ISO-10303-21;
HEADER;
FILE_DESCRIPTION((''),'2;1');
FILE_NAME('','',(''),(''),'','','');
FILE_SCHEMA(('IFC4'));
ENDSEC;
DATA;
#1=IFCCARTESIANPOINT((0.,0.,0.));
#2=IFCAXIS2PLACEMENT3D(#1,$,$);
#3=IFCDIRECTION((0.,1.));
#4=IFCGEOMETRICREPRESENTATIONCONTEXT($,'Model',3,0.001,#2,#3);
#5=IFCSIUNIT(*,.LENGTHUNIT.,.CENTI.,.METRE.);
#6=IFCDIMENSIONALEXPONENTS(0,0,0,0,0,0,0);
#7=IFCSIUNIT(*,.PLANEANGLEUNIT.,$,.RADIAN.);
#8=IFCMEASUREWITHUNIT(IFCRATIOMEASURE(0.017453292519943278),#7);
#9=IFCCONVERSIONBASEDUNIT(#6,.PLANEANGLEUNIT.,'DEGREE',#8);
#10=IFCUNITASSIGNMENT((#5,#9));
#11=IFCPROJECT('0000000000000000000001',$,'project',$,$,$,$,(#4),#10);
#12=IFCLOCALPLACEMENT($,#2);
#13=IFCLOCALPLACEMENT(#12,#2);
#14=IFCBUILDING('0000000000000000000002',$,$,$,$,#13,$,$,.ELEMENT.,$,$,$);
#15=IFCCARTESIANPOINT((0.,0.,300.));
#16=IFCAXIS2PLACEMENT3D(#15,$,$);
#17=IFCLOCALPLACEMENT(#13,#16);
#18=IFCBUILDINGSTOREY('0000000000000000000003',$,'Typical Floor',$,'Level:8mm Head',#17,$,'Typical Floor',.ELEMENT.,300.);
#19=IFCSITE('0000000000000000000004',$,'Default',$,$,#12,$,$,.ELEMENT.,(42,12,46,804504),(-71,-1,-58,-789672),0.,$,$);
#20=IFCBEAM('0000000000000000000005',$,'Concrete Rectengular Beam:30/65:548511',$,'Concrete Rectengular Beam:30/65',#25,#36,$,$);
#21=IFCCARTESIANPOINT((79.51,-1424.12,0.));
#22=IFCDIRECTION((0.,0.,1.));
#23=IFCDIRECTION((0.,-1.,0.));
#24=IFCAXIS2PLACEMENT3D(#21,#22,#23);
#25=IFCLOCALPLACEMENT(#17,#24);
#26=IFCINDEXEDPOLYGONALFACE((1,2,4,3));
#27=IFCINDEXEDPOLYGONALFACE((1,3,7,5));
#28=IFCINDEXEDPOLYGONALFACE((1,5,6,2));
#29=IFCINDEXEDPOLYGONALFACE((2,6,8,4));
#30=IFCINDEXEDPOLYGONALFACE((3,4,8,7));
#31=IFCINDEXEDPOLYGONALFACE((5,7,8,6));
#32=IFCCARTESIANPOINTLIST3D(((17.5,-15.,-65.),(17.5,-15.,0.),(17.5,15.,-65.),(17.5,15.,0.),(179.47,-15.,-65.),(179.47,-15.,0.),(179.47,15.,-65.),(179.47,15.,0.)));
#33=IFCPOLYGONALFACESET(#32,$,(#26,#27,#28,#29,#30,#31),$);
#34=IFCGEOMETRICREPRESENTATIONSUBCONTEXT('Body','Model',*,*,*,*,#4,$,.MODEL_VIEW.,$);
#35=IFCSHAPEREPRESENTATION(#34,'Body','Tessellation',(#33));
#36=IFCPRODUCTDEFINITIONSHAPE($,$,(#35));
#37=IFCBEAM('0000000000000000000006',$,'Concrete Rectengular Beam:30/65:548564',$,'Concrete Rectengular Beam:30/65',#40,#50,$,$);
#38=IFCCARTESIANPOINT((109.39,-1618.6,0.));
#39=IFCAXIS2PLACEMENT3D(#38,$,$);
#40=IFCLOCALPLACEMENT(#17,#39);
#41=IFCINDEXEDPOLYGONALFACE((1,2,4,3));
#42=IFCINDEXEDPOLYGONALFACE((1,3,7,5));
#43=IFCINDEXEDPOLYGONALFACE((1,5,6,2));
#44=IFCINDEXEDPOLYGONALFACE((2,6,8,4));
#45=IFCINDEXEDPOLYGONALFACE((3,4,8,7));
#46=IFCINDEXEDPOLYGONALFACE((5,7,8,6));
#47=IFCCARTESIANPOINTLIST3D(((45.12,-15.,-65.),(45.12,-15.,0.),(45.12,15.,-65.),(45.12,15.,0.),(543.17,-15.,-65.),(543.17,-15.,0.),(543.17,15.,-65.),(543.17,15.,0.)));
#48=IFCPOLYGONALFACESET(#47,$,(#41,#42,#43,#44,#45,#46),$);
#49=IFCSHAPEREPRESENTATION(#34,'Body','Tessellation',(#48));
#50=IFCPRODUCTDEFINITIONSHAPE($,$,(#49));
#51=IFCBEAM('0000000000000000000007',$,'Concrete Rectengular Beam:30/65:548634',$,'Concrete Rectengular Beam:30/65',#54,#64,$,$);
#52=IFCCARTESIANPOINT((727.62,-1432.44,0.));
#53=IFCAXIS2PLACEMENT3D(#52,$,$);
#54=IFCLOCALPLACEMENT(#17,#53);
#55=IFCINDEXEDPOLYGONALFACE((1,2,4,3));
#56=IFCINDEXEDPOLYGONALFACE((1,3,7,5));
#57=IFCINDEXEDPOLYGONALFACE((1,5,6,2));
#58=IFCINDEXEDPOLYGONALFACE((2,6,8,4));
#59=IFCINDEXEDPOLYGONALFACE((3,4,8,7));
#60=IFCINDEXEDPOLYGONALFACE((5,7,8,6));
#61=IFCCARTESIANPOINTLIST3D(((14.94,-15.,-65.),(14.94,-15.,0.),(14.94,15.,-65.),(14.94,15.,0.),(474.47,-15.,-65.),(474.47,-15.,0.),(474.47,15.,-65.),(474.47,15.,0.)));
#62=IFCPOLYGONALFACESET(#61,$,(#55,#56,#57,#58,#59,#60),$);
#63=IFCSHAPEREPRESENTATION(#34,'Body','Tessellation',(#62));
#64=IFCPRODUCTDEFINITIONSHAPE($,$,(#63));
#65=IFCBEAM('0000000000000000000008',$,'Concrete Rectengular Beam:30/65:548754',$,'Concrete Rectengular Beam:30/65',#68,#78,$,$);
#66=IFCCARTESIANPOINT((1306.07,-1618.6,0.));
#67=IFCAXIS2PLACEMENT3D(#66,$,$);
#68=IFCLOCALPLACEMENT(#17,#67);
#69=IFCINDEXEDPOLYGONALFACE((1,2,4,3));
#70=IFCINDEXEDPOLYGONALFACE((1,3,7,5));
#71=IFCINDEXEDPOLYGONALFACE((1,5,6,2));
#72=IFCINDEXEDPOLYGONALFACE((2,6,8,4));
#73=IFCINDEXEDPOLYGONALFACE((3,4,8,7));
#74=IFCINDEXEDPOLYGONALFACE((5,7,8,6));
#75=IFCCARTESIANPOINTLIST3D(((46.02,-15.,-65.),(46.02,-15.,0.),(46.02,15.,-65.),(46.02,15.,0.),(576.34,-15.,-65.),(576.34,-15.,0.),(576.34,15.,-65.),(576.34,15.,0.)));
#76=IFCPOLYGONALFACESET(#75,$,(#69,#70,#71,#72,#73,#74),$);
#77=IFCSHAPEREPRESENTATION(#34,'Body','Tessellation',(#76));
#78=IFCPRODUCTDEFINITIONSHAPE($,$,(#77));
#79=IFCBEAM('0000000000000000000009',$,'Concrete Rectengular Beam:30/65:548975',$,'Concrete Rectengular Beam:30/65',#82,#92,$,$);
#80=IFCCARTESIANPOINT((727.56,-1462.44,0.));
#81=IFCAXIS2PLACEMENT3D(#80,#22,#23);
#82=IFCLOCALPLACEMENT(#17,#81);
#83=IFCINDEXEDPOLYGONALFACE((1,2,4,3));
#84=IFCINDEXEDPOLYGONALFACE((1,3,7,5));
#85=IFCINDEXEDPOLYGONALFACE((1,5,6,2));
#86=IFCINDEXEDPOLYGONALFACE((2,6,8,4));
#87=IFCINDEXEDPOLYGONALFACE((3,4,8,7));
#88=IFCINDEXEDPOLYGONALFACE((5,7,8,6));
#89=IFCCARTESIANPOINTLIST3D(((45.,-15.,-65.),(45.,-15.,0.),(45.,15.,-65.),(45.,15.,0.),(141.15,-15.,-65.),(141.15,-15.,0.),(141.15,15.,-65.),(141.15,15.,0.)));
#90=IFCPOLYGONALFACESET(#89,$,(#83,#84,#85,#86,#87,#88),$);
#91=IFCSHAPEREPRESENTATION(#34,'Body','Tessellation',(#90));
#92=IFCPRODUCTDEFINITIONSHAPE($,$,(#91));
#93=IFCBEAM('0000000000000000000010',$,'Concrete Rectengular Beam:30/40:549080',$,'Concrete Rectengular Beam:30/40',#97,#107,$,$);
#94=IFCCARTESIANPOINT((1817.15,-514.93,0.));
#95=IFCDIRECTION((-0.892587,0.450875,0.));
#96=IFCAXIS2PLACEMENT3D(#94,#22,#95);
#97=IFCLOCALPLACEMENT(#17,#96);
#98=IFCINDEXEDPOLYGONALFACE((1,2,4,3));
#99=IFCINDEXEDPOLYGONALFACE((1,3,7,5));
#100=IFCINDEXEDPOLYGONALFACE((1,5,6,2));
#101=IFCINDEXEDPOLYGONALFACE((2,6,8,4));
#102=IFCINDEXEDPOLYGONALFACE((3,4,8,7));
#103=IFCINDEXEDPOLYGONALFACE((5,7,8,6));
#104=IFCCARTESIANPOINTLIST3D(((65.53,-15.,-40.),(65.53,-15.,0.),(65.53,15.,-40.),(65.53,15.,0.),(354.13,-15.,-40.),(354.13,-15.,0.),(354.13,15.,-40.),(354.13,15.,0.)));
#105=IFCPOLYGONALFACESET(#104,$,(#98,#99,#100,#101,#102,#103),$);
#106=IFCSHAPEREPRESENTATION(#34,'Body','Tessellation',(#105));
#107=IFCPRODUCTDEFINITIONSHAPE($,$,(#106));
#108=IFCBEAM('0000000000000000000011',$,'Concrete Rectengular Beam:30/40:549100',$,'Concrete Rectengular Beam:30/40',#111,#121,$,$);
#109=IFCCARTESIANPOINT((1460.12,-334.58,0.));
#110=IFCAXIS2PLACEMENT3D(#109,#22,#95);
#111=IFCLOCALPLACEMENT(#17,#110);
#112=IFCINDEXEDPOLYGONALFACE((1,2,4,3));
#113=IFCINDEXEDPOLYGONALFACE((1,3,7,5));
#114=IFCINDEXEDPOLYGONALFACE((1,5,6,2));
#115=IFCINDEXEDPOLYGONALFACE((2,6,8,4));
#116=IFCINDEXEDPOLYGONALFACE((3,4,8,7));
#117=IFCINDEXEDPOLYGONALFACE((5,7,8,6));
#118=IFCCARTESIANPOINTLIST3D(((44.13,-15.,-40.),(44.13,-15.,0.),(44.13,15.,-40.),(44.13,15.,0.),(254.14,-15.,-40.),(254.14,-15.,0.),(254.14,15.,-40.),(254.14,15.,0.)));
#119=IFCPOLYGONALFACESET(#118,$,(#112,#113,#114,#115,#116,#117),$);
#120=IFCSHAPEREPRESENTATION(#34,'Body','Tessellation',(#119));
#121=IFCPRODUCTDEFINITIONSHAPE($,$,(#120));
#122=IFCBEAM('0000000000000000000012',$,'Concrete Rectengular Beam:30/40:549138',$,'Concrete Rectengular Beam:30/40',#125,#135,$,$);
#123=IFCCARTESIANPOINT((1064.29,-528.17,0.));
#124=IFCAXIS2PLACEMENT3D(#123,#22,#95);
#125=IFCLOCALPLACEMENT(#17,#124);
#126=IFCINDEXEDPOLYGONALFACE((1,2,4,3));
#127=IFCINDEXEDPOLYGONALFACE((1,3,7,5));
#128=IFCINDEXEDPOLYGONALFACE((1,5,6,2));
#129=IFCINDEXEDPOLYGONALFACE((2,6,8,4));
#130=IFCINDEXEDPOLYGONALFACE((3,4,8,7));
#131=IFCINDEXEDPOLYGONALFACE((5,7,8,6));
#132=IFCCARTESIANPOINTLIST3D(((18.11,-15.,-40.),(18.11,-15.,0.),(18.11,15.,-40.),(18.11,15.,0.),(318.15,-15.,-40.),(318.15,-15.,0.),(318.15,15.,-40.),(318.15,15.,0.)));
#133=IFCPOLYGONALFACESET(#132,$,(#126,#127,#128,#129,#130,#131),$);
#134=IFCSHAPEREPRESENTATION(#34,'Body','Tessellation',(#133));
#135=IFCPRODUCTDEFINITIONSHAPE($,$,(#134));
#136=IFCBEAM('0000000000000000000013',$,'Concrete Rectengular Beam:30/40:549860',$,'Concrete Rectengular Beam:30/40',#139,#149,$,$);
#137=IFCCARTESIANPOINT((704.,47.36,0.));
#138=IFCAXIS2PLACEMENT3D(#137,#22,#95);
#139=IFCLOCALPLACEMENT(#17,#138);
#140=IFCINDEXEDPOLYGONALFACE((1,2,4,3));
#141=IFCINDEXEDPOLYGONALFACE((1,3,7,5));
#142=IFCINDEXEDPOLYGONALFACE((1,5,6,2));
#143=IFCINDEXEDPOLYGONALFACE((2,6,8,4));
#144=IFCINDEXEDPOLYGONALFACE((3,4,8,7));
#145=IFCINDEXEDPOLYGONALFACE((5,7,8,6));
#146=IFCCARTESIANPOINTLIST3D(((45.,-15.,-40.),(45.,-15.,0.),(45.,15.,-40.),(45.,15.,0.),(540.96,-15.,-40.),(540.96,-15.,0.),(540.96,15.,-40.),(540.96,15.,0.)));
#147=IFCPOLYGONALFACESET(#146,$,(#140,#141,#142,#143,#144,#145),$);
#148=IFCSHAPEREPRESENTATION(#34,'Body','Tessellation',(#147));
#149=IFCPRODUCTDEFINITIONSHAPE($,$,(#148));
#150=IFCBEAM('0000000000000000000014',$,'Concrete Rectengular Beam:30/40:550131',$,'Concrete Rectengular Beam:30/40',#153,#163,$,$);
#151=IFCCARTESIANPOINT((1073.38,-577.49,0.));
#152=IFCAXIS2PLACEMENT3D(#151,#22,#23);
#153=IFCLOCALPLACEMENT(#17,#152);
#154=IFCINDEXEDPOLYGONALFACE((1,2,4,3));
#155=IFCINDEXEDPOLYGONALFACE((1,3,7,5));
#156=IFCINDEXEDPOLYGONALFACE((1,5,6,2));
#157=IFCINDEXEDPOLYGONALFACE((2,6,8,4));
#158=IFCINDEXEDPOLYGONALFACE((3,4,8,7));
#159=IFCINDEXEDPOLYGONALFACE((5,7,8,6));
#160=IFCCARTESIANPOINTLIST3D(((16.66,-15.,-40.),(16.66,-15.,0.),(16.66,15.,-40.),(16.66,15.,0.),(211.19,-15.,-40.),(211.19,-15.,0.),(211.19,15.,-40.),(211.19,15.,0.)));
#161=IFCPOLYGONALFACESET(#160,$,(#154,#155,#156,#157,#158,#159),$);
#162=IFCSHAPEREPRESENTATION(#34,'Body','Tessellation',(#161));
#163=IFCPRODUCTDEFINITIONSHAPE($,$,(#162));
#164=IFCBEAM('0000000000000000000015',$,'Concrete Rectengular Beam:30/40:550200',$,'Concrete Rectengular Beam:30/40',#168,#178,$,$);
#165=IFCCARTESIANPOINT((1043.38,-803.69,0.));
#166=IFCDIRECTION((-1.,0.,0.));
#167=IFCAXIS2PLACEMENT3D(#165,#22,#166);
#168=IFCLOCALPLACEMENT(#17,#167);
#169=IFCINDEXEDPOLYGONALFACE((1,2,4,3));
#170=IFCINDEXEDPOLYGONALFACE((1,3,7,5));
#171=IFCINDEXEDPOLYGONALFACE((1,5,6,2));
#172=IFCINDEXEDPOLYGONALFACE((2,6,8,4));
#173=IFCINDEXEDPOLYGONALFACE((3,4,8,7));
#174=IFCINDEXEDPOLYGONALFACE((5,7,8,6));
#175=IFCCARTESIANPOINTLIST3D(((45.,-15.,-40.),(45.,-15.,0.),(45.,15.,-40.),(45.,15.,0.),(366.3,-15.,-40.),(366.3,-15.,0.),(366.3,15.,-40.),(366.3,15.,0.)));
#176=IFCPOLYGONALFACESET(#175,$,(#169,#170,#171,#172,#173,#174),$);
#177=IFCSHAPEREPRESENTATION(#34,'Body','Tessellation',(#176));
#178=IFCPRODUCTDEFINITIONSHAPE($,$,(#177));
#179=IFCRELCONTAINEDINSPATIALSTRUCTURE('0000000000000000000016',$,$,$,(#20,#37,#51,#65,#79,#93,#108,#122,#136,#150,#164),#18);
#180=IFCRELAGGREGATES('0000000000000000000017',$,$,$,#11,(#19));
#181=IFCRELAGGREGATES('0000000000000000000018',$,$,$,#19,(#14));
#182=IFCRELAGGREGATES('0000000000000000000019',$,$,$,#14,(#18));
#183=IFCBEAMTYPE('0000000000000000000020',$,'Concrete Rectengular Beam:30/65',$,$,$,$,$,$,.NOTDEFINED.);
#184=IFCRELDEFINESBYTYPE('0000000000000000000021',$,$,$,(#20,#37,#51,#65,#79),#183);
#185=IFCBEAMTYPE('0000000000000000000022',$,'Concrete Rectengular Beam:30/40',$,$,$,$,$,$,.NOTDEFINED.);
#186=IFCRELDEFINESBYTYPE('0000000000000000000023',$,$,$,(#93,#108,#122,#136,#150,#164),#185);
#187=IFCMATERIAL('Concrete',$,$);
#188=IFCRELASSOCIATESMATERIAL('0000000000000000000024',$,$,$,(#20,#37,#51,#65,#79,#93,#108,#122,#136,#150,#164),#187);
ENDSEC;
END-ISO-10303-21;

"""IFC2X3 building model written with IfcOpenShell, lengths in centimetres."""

from ifc_helpers import new_model, entity, si_unit, converted_unit, direction, frame, frame_2d, origin, place, context, subcontext, project, spatial, rectangle, extrude, material, type_object, element, save


model = new_model("IFC2X3")

# Units and contexts
model_context = context("Model", 3, precision=0.001, world=origin(), true_north=direction((0.0, 1.0)))
body_context = subcontext(model_context, "Body", "Model", "MODEL_VIEW")
ifc_project = project(units=[si_unit("LENGTHUNIT", "METRE", prefix="CENTI"), converted_unit("PLANEANGLEUNIT", "DEGREE", entity("IfcRatioMeasure", 0.017453292519943278), si_unit("PLANEANGLEUNIT", "RADIAN"), dimensions=[0, 0, 0, 0, 0, 0, 0])], contexts=[model_context])

# Site, building, storey
site_placement = place(None, origin())
site = spatial("IfcSite", under=ifc_project, at=site_placement, Name="Default", CompositionType="ELEMENT", RefLatitude=(42, 12, 46, 804504), RefLongitude=(-71, -1, -58, -789672), RefElevation=0.0)
building_placement = place(site_placement, origin())
building = spatial("IfcBuilding", under=site, at=building_placement, CompositionType="ELEMENT")
storey_placement = place(building_placement, frame((0.0, 0.0, 300.0)))
storey = spatial("IfcBuildingStorey", under=building, at=storey_placement, Name="Typical Floor", ObjectType="Level:8mm Head", LongName="Typical Floor", CompositionType="ELEMENT", Elevation=300.0)

# Beams
ifc_material = material(Name="Concrete")
beam_type_1 = type_object("IfcBeamType", Name="Concrete Rectengular Beam:30/65", PredefinedType="NOTDEFINED")
beam_1_placement = place(storey_placement, frame((79.51, -1424.12, 0.0), z_axis=(0.0, 0.0, 1.0), x_axis=(0.0, -1.0, 0.0)))
element("IfcBeam", 1, at=beam_1_placement, inside=storey, type_object=beam_type_1, material=ifc_material, Name="Concrete Rectengular Beam:30/65:548511", ObjectType="Concrete Rectengular Beam:30/65", context=body_context, shape_type="SweptSolid", body=[
    extrude(rectangle(XDim=65.0, YDim=30.0, at=frame_2d((0.0, 0.0), x_axis=(1.0, 0.0))), frame((17.5, 0.0, -32.5), z_axis=(1.0, 0.0, 0.0), x_axis=(0.0, 0.0, -1.0)), (0.0, 0.0, 1.0), 161.97),
])
beam_2_placement = place(storey_placement, frame((109.39, -1618.6, 0.0)))
element("IfcBeam", 2, at=beam_2_placement, inside=storey, type_object=beam_type_1, material=ifc_material, Name="Concrete Rectengular Beam:30/65:548564", ObjectType="Concrete Rectengular Beam:30/65", context=body_context, shape_type="SweptSolid", body=[
    extrude(rectangle(XDim=65.0, YDim=30.0, at=frame_2d((0.0, 0.0), x_axis=(1.0, 0.0))), frame((45.12, 0.0, -32.5), z_axis=(1.0, 0.0, 0.0), x_axis=(0.0, 0.0, -1.0)), (0.0, 0.0, 1.0), 498.05),
])
beam_3_placement = place(storey_placement, frame((727.62, -1432.44, 0.0)))
element("IfcBeam", 3, at=beam_3_placement, inside=storey, type_object=beam_type_1, material=ifc_material, Name="Concrete Rectengular Beam:30/65:548634", ObjectType="Concrete Rectengular Beam:30/65", context=body_context, shape_type="SweptSolid", body=[
    extrude(rectangle(XDim=65.0, YDim=30.0, at=frame_2d((0.0, 0.0), x_axis=(1.0, 0.0))), frame((14.94, 0.0, -32.5), z_axis=(1.0, 0.0, 0.0), x_axis=(0.0, 0.0, -1.0)), (0.0, 0.0, 1.0), 459.53),
])
beam_4_placement = place(storey_placement, frame((1306.07, -1618.6, 0.0)))
element("IfcBeam", 4, at=beam_4_placement, inside=storey, type_object=beam_type_1, material=ifc_material, Name="Concrete Rectengular Beam:30/65:548754", ObjectType="Concrete Rectengular Beam:30/65", context=body_context, shape_type="SweptSolid", body=[
    extrude(rectangle(XDim=65.0, YDim=30.0, at=frame_2d((0.0, 0.0), x_axis=(1.0, 0.0))), frame((46.02, 0.0, -32.5), z_axis=(1.0, 0.0, 0.0), x_axis=(0.0, 0.0, -1.0)), (0.0, 0.0, 1.0), 530.32),
])
beam_5_placement = place(storey_placement, frame((727.56, -1462.44, 0.0), z_axis=(0.0, 0.0, 1.0), x_axis=(0.0, -1.0, 0.0)))
element("IfcBeam", 5, at=beam_5_placement, inside=storey, type_object=beam_type_1, material=ifc_material, Name="Concrete Rectengular Beam:30/65:548975", ObjectType="Concrete Rectengular Beam:30/65", context=body_context, shape_type="SweptSolid", body=[
    extrude(rectangle(XDim=65.0, YDim=30.0, at=frame_2d((0.0, 0.0), x_axis=(1.0, 0.0))), frame((45.0, 0.0, -32.5), z_axis=(1.0, 0.0, 0.0), x_axis=(0.0, 0.0, -1.0)), (0.0, 0.0, 1.0), 96.15),
])
beam_type_2 = type_object("IfcBeamType", Name="Concrete Rectengular Beam:30/40", PredefinedType="NOTDEFINED")
beam_6_placement = place(storey_placement, frame((1817.15, -514.93, 0.0), z_axis=(0.0, 0.0, 1.0), x_axis=(-0.892587, 0.450875, 0.0)))
element("IfcBeam", 6, at=beam_6_placement, inside=storey, type_object=beam_type_2, material=ifc_material, Name="Concrete Rectengular Beam:30/40:549080", ObjectType="Concrete Rectengular Beam:30/40", context=body_context, shape_type="SweptSolid", body=[
    extrude(rectangle(XDim=40.0, YDim=30.0, at=frame_2d((0.0, 0.0), x_axis=(1.0, 0.0))), frame((65.53, 0.0, -20.0), z_axis=(1.0, 0.0, 0.0), x_axis=(0.0, 0.0, -1.0)), (0.0, 0.0, 1.0), 288.61),
])
beam_7_placement = place(storey_placement, frame((1460.12, -334.58, 0.0), z_axis=(0.0, 0.0, 1.0), x_axis=(-0.892587, 0.450875, 0.0)))
element("IfcBeam", 7, at=beam_7_placement, inside=storey, type_object=beam_type_2, material=ifc_material, Name="Concrete Rectengular Beam:30/40:549100", ObjectType="Concrete Rectengular Beam:30/40", context=body_context, shape_type="SweptSolid", body=[
    extrude(rectangle(XDim=40.0, YDim=30.0, at=frame_2d((0.0, 0.0), x_axis=(1.0, 0.0))), frame((44.13, 0.0, -20.0), z_axis=(1.0, 0.0, 0.0), x_axis=(0.0, 0.0, -1.0)), (0.0, 0.0, 1.0), 210.01),
])
beam_8_placement = place(storey_placement, frame((1064.29, -528.17, 0.0), z_axis=(0.0, 0.0, 1.0), x_axis=(-0.892587, 0.450875, 0.0)))
element("IfcBeam", 8, at=beam_8_placement, inside=storey, type_object=beam_type_2, material=ifc_material, Name="Concrete Rectengular Beam:30/40:549138", ObjectType="Concrete Rectengular Beam:30/40", context=body_context, shape_type="SweptSolid", body=[
    extrude(rectangle(XDim=40.0, YDim=30.0, at=frame_2d((0.0, 0.0), x_axis=(1.0, 0.0))), frame((18.11, 0.0, -20.0), z_axis=(1.0, 0.0, 0.0), x_axis=(0.0, 0.0, -1.0)), (0.0, 0.0, 1.0), 300.04),
])
beam_9_placement = place(storey_placement, frame((704.0, 47.36, 0.0), z_axis=(0.0, 0.0, 1.0), x_axis=(-0.892587, 0.450875, 0.0)))
element("IfcBeam", 9, at=beam_9_placement, inside=storey, type_object=beam_type_2, material=ifc_material, Name="Concrete Rectengular Beam:30/40:549860", ObjectType="Concrete Rectengular Beam:30/40", context=body_context, shape_type="SweptSolid", body=[
    extrude(rectangle(XDim=40.0, YDim=30.0, at=frame_2d((0.0, 0.0), x_axis=(1.0, 0.0))), frame((45.0, 0.0, -20.0), z_axis=(1.0, 0.0, 0.0), x_axis=(0.0, 0.0, -1.0)), (0.0, 0.0, 1.0), 495.96),
])
beam_10_placement = place(storey_placement, frame((1073.38, -577.49, 0.0), z_axis=(0.0, 0.0, 1.0), x_axis=(0.0, -1.0, 0.0)))
element("IfcBeam", 10, at=beam_10_placement, inside=storey, type_object=beam_type_2, material=ifc_material, Name="Concrete Rectengular Beam:30/40:550131", ObjectType="Concrete Rectengular Beam:30/40", context=body_context, shape_type="SweptSolid", body=[
    extrude(rectangle(XDim=40.0, YDim=30.0, at=frame_2d((0.0, 0.0), x_axis=(1.0, 0.0))), frame((16.66, 0.0, -20.0), z_axis=(1.0, 0.0, 0.0), x_axis=(0.0, 0.0, -1.0)), (0.0, 0.0, 1.0), 194.53),
])
beam_11_placement = place(storey_placement, frame((1043.38, -803.69, 0.0), z_axis=(0.0, 0.0, 1.0), x_axis=(-1.0, 0.0, 0.0)))
element("IfcBeam", 11, at=beam_11_placement, inside=storey, type_object=beam_type_2, material=ifc_material, Name="Concrete Rectengular Beam:30/40:550200", ObjectType="Concrete Rectengular Beam:30/40", context=body_context, shape_type="SweptSolid", body=[
    extrude(rectangle(XDim=40.0, YDim=30.0, at=frame_2d((0.0, 0.0), x_axis=(1.0, 0.0))), frame((45.0, 0.0, -20.0), z_axis=(1.0, 0.0, 0.0), x_axis=(0.0, 0.0, -1.0)), (0.0, 0.0, 1.0), 321.3),
])

save(model, "model.ifc")
